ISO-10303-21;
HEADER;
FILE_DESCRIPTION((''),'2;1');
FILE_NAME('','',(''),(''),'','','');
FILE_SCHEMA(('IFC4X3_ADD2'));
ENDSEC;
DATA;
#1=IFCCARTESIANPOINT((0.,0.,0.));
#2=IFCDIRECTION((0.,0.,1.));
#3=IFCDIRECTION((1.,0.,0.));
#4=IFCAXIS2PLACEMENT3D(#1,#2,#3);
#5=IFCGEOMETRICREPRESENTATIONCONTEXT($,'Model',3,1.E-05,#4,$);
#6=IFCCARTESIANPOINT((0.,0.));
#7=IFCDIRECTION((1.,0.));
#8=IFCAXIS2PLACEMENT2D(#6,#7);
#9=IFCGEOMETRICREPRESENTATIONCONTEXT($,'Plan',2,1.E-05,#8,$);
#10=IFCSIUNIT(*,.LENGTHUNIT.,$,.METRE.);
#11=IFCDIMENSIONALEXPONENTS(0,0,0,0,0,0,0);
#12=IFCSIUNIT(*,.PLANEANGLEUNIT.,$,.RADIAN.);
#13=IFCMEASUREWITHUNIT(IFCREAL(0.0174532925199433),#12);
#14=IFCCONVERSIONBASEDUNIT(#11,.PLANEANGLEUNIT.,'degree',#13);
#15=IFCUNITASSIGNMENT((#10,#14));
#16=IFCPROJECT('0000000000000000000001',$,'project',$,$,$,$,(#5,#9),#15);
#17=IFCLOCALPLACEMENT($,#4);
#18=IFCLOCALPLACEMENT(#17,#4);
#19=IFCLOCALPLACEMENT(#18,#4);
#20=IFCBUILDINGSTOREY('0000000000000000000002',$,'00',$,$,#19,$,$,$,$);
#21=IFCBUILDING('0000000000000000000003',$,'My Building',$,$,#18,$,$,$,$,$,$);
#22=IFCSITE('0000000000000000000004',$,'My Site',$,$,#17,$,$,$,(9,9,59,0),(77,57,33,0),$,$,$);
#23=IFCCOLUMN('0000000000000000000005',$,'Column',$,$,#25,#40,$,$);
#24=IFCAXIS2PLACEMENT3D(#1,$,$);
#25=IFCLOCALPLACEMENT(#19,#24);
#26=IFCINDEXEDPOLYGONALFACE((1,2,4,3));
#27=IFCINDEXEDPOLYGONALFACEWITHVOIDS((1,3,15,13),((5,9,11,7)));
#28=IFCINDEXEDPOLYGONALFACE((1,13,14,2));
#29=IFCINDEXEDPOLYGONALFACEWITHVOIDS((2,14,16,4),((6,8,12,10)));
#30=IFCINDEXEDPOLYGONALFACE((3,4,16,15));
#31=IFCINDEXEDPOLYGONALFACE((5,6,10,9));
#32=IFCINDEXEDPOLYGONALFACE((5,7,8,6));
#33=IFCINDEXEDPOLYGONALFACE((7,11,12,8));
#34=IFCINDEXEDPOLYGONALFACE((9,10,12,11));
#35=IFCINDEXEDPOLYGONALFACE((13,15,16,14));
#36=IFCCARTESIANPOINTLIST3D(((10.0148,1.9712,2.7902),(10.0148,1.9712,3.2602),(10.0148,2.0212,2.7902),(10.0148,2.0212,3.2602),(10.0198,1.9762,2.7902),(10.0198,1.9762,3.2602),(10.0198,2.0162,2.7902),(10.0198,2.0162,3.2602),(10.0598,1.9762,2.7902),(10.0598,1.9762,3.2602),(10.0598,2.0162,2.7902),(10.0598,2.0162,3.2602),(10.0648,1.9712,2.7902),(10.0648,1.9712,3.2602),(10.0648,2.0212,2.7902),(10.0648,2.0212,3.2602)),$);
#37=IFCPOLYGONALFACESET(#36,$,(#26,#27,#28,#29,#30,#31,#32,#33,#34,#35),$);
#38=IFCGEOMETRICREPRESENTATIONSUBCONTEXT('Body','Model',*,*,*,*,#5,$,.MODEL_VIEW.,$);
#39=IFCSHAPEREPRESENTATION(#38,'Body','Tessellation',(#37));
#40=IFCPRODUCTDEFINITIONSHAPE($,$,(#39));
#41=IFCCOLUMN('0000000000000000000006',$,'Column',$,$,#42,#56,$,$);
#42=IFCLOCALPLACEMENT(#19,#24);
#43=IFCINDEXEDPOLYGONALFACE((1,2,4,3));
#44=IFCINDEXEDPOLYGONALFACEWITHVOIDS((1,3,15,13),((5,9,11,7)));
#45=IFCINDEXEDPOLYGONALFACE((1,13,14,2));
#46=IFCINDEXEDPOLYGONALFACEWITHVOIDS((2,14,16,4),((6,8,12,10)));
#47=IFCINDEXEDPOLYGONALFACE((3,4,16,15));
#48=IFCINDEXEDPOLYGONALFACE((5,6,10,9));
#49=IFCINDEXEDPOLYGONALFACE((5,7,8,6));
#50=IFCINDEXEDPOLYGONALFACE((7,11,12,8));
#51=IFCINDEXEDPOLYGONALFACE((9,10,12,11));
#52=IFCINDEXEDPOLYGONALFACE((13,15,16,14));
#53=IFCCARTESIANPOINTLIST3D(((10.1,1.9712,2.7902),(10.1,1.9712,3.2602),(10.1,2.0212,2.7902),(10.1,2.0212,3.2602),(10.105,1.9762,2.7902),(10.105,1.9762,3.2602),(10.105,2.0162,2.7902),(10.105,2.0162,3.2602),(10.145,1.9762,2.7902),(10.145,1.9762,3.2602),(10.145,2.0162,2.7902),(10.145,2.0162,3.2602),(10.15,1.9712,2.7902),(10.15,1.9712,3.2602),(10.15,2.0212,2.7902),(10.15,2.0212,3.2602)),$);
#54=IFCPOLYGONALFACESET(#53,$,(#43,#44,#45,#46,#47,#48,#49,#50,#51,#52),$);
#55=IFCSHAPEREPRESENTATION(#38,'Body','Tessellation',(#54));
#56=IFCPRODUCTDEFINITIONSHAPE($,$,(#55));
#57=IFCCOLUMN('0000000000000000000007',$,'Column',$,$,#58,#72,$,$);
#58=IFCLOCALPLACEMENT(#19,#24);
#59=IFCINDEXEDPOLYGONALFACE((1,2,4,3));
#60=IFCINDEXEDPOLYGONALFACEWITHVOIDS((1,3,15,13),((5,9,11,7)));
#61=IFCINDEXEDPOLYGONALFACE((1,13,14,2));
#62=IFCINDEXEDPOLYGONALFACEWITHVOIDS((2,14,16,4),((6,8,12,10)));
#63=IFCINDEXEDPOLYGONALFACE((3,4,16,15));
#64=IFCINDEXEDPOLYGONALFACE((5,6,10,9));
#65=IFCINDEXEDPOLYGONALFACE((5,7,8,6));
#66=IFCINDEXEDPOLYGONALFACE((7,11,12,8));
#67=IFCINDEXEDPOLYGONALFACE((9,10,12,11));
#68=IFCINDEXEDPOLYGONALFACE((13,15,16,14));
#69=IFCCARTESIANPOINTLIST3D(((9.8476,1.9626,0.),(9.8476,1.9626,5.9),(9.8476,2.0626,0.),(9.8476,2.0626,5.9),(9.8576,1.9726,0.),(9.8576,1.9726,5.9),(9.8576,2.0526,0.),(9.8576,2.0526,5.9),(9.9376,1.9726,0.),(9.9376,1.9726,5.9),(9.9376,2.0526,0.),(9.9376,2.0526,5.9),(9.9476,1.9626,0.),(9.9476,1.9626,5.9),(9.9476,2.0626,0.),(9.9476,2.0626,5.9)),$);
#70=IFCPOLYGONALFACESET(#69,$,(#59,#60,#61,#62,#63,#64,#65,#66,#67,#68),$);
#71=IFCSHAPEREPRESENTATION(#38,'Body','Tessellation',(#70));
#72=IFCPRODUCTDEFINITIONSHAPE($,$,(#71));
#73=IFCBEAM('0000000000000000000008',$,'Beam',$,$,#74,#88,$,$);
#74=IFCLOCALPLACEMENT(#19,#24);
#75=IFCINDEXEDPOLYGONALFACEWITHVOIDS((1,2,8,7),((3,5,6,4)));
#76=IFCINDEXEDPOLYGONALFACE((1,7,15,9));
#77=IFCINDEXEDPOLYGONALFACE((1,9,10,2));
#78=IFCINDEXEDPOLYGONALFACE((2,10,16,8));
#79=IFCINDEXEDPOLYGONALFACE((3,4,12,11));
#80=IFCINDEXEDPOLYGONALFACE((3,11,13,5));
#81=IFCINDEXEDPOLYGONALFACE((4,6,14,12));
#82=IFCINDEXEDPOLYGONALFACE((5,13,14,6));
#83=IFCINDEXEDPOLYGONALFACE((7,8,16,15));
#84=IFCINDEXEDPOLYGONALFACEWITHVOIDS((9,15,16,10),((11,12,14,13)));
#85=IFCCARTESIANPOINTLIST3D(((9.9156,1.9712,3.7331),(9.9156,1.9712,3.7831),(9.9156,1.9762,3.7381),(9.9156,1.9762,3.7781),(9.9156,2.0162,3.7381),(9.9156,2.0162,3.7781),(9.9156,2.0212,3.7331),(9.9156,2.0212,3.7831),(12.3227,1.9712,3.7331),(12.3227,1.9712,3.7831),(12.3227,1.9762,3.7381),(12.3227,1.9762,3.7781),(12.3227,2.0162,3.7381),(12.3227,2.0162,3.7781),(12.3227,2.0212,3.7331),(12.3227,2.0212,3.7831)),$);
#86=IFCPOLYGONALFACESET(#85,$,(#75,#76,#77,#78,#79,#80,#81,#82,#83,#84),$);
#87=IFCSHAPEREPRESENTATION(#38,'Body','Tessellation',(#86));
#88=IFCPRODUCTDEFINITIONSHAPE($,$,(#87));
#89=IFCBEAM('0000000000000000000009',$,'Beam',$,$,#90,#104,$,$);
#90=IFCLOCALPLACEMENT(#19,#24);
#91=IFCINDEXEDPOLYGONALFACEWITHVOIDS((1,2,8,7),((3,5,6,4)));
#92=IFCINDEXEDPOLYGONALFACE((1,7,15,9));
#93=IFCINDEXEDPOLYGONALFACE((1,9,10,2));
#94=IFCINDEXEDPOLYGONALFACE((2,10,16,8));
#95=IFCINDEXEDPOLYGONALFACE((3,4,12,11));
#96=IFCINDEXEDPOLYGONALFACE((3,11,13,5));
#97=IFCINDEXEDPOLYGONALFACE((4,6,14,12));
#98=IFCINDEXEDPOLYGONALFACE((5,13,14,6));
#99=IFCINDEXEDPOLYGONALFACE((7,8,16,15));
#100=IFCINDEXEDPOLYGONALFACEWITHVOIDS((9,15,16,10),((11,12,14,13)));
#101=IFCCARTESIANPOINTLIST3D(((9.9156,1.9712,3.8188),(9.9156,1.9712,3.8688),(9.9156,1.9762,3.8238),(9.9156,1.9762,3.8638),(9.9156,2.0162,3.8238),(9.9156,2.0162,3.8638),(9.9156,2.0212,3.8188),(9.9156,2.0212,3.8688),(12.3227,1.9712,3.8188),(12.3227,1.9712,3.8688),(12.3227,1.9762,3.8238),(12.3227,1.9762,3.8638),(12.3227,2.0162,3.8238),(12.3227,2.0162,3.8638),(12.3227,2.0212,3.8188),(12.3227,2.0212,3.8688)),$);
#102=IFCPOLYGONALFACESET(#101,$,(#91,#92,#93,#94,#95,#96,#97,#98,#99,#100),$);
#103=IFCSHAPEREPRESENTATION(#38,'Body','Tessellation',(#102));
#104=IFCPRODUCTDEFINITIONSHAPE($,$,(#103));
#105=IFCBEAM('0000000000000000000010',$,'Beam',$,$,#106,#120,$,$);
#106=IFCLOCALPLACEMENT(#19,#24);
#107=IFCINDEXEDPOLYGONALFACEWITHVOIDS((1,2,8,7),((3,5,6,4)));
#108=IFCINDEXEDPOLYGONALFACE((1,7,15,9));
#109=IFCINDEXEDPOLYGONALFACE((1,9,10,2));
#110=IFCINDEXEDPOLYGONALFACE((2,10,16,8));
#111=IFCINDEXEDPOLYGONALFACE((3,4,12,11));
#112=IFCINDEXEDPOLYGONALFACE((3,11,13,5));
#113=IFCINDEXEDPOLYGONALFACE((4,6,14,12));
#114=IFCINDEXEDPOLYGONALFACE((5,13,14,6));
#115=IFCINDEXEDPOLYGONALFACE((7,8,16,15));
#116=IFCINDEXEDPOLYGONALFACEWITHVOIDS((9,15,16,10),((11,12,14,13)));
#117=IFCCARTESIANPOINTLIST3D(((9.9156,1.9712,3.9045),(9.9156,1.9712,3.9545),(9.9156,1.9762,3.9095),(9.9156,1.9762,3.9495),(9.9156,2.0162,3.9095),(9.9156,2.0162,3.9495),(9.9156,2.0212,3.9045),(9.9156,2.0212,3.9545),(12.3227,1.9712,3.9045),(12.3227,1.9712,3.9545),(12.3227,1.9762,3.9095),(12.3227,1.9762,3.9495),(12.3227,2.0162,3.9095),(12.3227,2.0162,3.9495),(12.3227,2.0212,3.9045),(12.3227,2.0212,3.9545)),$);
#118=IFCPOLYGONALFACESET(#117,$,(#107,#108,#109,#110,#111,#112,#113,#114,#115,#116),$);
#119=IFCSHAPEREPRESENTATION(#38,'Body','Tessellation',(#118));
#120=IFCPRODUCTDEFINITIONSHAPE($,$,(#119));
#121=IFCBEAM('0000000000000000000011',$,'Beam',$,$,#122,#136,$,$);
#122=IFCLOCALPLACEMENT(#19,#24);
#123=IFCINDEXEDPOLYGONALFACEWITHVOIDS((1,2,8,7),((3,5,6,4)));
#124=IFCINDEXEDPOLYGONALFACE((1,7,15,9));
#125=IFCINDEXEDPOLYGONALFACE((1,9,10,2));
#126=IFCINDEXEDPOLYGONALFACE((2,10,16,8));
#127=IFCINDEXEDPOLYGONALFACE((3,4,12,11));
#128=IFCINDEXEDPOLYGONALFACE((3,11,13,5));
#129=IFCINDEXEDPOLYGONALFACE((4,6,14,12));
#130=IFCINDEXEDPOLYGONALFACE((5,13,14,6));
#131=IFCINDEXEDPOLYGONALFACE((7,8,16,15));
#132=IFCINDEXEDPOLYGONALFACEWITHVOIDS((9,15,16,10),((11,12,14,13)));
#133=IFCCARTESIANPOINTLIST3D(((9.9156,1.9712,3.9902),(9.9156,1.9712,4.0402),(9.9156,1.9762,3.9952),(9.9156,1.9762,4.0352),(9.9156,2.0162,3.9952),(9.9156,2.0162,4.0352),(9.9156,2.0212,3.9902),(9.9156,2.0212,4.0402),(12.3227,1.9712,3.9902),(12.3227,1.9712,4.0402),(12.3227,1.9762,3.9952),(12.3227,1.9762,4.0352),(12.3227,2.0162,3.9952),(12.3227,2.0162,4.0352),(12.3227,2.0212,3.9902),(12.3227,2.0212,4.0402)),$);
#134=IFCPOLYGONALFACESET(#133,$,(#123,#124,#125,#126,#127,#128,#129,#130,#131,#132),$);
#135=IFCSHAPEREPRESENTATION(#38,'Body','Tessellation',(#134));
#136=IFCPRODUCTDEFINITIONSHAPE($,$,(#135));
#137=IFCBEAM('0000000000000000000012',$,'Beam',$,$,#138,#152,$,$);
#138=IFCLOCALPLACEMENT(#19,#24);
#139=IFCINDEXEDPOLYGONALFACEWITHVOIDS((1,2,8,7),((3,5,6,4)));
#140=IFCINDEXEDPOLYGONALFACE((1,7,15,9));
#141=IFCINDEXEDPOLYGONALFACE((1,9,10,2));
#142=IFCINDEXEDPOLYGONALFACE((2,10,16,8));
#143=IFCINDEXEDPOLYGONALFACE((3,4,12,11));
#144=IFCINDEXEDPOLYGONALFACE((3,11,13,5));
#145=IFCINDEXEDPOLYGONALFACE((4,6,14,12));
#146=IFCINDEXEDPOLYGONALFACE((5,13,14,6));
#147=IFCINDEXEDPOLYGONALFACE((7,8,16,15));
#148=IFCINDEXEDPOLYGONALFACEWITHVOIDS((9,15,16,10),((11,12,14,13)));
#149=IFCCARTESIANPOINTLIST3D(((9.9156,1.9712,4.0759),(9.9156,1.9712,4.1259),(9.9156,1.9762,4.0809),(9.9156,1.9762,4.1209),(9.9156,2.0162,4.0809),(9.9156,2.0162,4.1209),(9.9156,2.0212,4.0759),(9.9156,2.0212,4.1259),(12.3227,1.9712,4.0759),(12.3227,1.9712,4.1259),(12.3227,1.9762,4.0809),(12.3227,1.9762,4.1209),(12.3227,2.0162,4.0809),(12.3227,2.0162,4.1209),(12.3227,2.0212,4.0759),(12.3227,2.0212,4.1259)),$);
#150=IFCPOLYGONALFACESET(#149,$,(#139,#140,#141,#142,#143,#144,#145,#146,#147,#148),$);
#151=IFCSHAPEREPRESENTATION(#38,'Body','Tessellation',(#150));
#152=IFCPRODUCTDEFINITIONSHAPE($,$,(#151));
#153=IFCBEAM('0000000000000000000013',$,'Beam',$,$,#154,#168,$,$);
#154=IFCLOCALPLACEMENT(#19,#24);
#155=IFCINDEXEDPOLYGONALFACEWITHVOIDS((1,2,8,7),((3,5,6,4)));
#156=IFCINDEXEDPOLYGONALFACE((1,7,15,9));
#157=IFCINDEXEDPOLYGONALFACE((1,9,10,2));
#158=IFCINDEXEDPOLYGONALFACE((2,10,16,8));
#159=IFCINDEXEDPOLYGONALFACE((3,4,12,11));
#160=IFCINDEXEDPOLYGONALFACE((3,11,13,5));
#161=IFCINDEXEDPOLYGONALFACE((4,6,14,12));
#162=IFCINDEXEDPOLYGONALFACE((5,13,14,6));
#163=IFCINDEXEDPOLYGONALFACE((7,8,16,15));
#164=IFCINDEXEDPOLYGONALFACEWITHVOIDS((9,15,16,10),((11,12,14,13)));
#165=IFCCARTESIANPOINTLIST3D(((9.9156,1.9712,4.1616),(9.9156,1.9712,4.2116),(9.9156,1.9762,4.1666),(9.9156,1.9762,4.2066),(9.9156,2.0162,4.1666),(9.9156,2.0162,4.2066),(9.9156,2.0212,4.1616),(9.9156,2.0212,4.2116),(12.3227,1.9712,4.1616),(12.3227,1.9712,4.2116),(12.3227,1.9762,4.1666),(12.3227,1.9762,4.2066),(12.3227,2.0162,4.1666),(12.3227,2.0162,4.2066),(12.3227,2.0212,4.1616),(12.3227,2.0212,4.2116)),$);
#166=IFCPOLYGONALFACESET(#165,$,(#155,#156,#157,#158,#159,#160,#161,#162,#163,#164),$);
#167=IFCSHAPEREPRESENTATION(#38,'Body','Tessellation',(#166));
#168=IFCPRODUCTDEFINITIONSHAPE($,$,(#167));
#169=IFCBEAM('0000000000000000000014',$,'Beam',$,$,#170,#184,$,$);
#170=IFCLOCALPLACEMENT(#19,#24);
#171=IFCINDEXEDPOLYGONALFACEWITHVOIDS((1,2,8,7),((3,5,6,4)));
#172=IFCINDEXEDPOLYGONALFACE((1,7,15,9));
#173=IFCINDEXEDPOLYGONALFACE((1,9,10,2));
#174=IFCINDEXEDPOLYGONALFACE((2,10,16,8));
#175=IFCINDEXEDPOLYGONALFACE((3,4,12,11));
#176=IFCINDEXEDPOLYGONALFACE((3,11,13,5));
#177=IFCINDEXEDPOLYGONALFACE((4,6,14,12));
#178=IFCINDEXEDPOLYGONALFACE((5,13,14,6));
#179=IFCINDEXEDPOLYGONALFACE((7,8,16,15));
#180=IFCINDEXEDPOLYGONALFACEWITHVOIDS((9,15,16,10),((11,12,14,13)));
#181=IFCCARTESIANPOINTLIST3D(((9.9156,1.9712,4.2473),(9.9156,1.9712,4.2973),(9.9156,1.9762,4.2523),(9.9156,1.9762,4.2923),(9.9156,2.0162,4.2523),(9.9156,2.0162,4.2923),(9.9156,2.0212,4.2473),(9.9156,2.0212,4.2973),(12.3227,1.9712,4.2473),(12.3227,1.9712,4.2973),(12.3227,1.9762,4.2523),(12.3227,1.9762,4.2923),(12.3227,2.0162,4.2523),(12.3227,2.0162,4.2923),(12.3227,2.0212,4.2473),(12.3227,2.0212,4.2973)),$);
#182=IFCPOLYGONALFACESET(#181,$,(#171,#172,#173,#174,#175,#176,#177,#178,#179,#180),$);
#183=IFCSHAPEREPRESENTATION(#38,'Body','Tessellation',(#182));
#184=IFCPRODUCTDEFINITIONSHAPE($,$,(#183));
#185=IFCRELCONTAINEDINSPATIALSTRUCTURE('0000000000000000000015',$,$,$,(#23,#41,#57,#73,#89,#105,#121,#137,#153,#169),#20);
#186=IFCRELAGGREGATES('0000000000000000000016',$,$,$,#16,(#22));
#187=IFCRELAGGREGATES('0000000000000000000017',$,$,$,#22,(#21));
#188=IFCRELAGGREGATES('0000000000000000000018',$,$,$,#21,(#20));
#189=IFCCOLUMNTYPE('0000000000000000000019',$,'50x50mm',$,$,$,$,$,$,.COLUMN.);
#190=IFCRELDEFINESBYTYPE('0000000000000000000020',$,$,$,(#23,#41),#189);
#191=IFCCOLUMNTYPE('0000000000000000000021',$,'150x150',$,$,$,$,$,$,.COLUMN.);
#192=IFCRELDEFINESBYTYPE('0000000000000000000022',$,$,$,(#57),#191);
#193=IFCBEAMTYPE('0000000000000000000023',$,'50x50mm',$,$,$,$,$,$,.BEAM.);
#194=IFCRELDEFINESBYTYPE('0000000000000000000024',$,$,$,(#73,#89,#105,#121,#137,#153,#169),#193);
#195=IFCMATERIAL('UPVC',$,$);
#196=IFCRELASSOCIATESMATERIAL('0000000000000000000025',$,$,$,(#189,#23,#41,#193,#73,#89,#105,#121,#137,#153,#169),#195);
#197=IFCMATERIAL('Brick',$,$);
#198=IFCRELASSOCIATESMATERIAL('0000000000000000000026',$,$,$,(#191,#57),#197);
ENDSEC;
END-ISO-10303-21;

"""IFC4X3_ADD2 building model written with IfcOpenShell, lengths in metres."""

from ifc_helpers import new_model, entity, si_unit, converted_unit, frame, origin_with_axes, origin_2d_with_axis, place, context, subcontext, project, spatial, hollow_rectangle, extrude, material, material_profile, profile_set, profile_usage, type_object, element, save


model = new_model("IFC4X3_ADD2")

# Units and contexts
model_context = context("Model", 3, precision=1e-05, world=origin_with_axes())
plan_context = context("Plan", 2, precision=1e-05, world=origin_2d_with_axis())
body_context = subcontext(model_context, "Body", "Model", "MODEL_VIEW")
ifc_project = project(units=[si_unit("LENGTHUNIT", "METRE"), converted_unit("PLANEANGLEUNIT", "degree", entity("IfcReal", 0.0174532925199433), si_unit("PLANEANGLEUNIT", "RADIAN"), dimensions=[0, 0, 0, 0, 0, 0, 0])], contexts=[model_context, plan_context])

# Site, building, storey
site_placement = place(None, origin_with_axes())
site = spatial("IfcSite", under=ifc_project, at=site_placement, Name="My Site", RefLatitude=(9, 9, 59, 0), RefLongitude=(77, 57, 33, 0))
building_placement = place(site_placement, origin_with_axes())
building = spatial("IfcBuilding", under=site, at=building_placement, Name="My Building")
storey_placement = place(building_placement, origin_with_axes())
storey = spatial("IfcBuildingStorey", under=building, at=storey_placement, Name="00")

# Columns
ifc_material_1 = material(Name="UPVC")
ifc_material_profile_1 = material_profile(ifc_material_1, hollow_rectangle(XDim=0.05, YDim=0.05, WallThickness=0.005))
ifc_profile_set_1 = profile_set([ifc_material_profile_1])
ifc_profile_usage_1 = profile_usage(ifc_profile_set_1, cardinal=5)
column_type_1 = type_object("IfcColumnType", Name="50x50mm", PredefinedType="COLUMN", material=ifc_profile_set_1)
column_1_placement = place(storey_placement, frame((10.0398, 1.9962, 2.7902), z_axis=(0.0, 0.0, 1.0), x_axis=(1.0, 0.0, 0.0)))
element("IfcColumn", 1, at=column_1_placement, inside=storey, type_object=column_type_1, material=ifc_profile_usage_1, Name="Column", context=body_context, shape_type="SweptSolid", body=[
    extrude(hollow_rectangle(XDim=0.05, YDim=0.05, WallThickness=0.005), origin_with_axes(), (0.0, 0.0, 1.0), 0.47),
])
ifc_profile_usage_2 = profile_usage(ifc_profile_set_1, cardinal=5)
column_2_placement = place(storey_placement, frame((10.125, 1.9962, 2.7902), z_axis=(0.0, 0.0, 1.0), x_axis=(1.0, 0.0, 0.0)))
element("IfcColumn", 2, at=column_2_placement, inside=storey, type_object=column_type_1, material=ifc_profile_usage_2, Name="Column", context=body_context, shape_type="SweptSolid", body=[
    extrude(hollow_rectangle(XDim=0.05, YDim=0.05, WallThickness=0.005), origin_with_axes(), (0.0, 0.0, 1.0), 0.47),
])
ifc_material_2 = material(Name="Brick")
ifc_material_profile_2 = material_profile(ifc_material_2, hollow_rectangle(XDim=0.1, YDim=0.1, WallThickness=0.01))
ifc_profile_set_2 = profile_set([ifc_material_profile_2])
ifc_profile_usage_3 = profile_usage(ifc_profile_set_2, cardinal=5)
column_type_2 = type_object("IfcColumnType", Name="150x150", PredefinedType="COLUMN", material=ifc_profile_set_2)
column_3_placement = place(storey_placement, frame((9.8976, 2.0126, 0.0), z_axis=(0.0, 0.0, 1.0), x_axis=(1.0, 0.0, 0.0)))
element("IfcColumn", 3, at=column_3_placement, inside=storey, type_object=column_type_2, material=ifc_profile_usage_3, Name="Column", context=body_context, shape_type="SweptSolid", body=[
    extrude(hollow_rectangle(XDim=0.1, YDim=0.1, WallThickness=0.01), origin_with_axes(), (0.0, 0.0, 1.0), 5.9),
])

# Beams
ifc_material_profile_3 = material_profile(ifc_material_1, hollow_rectangle(XDim=0.05, YDim=0.05, WallThickness=0.005))
ifc_profile_set_3 = profile_set([ifc_material_profile_3])
ifc_profile_usage_4 = profile_usage(ifc_profile_set_3, cardinal=5)
beam_type = type_object("IfcBeamType", Name="50x50mm", PredefinedType="BEAM", material=ifc_profile_set_3)
beam_1_placement = place(storey_placement, frame((9.9156, 1.9962, 3.7581), z_axis=(1.0, 0.0, 0.000001), x_axis=(0.0, 1.0, 0.0)))
element("IfcBeam", 4, at=beam_1_placement, inside=storey, type_object=beam_type, material=ifc_profile_usage_4, Name="Beam", context=body_context, shape_type="SweptSolid", body=[
    extrude(hollow_rectangle(XDim=0.05, YDim=0.05, WallThickness=0.005), origin_with_axes(), (0.0, 0.0, 1.0), 2.4071),
])
ifc_profile_usage_5 = profile_usage(ifc_profile_set_3, cardinal=5)
beam_2_placement = place(storey_placement, frame((9.9156, 1.9962, 3.8438), z_axis=(1.0, 0.0, 0.000001), x_axis=(0.0, 1.0, 0.0)))
element("IfcBeam", 5, at=beam_2_placement, inside=storey, type_object=beam_type, material=ifc_profile_usage_5, Name="Beam", context=body_context, shape_type="SweptSolid", body=[
    extrude(hollow_rectangle(XDim=0.05, YDim=0.05, WallThickness=0.005), origin_with_axes(), (0.0, 0.0, 1.0), 2.4071),
])
ifc_profile_usage_6 = profile_usage(ifc_profile_set_3, cardinal=5)
beam_3_placement = place(storey_placement, frame((9.9156, 1.9962, 3.9295), z_axis=(1.0, 0.0, 0.000001), x_axis=(0.0, 1.0, 0.0)))
element("IfcBeam", 6, at=beam_3_placement, inside=storey, type_object=beam_type, material=ifc_profile_usage_6, Name="Beam", context=body_context, shape_type="SweptSolid", body=[
    extrude(hollow_rectangle(XDim=0.05, YDim=0.05, WallThickness=0.005), origin_with_axes(), (0.0, 0.0, 1.0), 2.4071),
])
ifc_profile_usage_7 = profile_usage(ifc_profile_set_3, cardinal=5)
beam_4_placement = place(storey_placement, frame((9.9156, 1.9962, 4.0152), z_axis=(1.0, 0.0, 0.000001), x_axis=(0.0, 1.0, 0.0)))
element("IfcBeam", 7, at=beam_4_placement, inside=storey, type_object=beam_type, material=ifc_profile_usage_7, Name="Beam", context=body_context, shape_type="SweptSolid", body=[
    extrude(hollow_rectangle(XDim=0.05, YDim=0.05, WallThickness=0.005), origin_with_axes(), (0.0, 0.0, 1.0), 2.4071),
])
ifc_profile_usage_8 = profile_usage(ifc_profile_set_3, cardinal=5)
beam_5_placement = place(storey_placement, frame((9.9156, 1.9962, 4.1009), z_axis=(1.0, 0.0, 0.000001), x_axis=(0.0, 1.0, 0.0)))
element("IfcBeam", 8, at=beam_5_placement, inside=storey, type_object=beam_type, material=ifc_profile_usage_8, Name="Beam", context=body_context, shape_type="SweptSolid", body=[
    extrude(hollow_rectangle(XDim=0.05, YDim=0.05, WallThickness=0.005), origin_with_axes(), (0.0, 0.0, 1.0), 2.4071),
])
ifc_profile_usage_9 = profile_usage(ifc_profile_set_3, cardinal=5)
beam_6_placement = place(storey_placement, frame((9.9156, 1.9962, 4.1866), z_axis=(1.0, 0.0, 0.000001), x_axis=(0.0, 1.0, 0.0)))
element("IfcBeam", 9, at=beam_6_placement, inside=storey, type_object=beam_type, material=ifc_profile_usage_9, Name="Beam", context=body_context, shape_type="SweptSolid", body=[
    extrude(hollow_rectangle(XDim=0.05, YDim=0.05, WallThickness=0.005), origin_with_axes(), (0.0, 0.0, 1.0), 2.4071),
])
ifc_profile_usage_10 = profile_usage(ifc_profile_set_3, cardinal=5)
beam_7_placement = place(storey_placement, frame((9.9156, 1.9962, 4.2723), z_axis=(1.0, 0.0, 0.000001), x_axis=(0.0, 1.0, 0.0)))
element("IfcBeam", 10, at=beam_7_placement, inside=storey, type_object=beam_type, material=ifc_profile_usage_10, Name="Beam", context=body_context, shape_type="SweptSolid", body=[
    extrude(hollow_rectangle(XDim=0.05, YDim=0.05, WallThickness=0.005), origin_with_axes(), (0.0, 0.0, 1.0), 2.4071),
])

save(model, "model.ifc")
